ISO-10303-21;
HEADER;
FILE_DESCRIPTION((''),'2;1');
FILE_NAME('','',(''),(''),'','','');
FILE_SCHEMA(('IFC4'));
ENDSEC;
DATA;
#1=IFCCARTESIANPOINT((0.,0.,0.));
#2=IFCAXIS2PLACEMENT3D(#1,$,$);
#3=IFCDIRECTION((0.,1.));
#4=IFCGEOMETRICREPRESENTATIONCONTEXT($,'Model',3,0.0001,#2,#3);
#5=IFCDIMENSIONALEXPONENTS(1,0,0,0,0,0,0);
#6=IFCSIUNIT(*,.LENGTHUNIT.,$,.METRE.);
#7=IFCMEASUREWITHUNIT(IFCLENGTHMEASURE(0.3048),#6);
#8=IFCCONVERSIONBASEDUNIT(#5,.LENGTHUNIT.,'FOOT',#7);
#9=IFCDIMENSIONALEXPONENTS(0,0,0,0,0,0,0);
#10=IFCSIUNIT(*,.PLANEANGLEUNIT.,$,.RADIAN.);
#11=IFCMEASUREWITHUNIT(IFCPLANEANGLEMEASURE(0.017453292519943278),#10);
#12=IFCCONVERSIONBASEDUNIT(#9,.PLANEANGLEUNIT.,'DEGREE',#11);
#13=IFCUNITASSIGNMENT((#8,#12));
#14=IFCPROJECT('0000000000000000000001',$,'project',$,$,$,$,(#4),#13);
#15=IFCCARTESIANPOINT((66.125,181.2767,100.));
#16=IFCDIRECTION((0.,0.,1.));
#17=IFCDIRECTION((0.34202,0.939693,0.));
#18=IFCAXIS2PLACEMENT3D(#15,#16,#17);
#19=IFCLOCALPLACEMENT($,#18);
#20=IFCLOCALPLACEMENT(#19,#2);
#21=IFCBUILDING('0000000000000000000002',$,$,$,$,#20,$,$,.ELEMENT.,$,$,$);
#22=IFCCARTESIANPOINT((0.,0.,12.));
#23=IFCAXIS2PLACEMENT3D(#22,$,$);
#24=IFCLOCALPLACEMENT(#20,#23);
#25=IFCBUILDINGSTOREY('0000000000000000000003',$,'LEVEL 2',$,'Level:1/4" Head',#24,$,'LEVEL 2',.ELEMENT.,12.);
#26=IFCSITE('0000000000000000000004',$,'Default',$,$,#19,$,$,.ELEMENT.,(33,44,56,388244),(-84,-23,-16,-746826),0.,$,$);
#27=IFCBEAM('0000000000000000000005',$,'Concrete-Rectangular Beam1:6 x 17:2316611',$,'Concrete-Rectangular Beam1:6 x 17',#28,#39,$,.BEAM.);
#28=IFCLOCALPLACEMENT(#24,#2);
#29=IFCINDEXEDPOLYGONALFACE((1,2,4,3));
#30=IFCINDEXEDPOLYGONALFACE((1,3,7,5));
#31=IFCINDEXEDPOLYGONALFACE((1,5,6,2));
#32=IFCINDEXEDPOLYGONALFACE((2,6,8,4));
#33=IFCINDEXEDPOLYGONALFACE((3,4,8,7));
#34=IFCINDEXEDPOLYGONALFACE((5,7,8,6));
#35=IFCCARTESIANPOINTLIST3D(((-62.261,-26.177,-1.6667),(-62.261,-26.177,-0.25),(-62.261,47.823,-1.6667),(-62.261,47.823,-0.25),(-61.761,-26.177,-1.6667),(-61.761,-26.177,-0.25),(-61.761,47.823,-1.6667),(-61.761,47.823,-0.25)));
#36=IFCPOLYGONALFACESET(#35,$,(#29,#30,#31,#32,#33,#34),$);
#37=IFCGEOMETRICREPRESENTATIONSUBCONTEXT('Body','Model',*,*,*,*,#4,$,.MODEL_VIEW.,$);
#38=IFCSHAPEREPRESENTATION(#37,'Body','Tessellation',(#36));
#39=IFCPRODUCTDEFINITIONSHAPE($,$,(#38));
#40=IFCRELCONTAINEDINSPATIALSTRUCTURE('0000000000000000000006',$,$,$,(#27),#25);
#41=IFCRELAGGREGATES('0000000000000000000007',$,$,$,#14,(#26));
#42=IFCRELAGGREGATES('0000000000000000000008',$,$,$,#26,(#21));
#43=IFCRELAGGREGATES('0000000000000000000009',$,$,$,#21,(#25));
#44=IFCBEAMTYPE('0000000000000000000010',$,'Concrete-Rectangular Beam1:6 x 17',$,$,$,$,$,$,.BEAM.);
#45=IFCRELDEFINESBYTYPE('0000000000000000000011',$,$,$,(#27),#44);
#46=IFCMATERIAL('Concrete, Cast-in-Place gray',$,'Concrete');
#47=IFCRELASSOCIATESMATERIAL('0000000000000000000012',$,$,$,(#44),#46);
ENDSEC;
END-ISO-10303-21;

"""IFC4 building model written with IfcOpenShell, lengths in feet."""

from ifc_helpers import new_model, entity, si_unit, converted_unit, direction, frame, frame_2d, origin, place, context, subcontext, project, spatial, rectangle, extrude, source, transform, mapped, material, material_profile, profile_set, type_object, type_shapes, element, save


model = new_model("IFC4")

# Units and contexts
model_context = context("Model", 3, precision=0.0001, world=origin(), true_north=direction((0.0, 1.0)))
body_context = subcontext(model_context, "Body", "Model", "MODEL_VIEW")
ifc_project = project(units=[converted_unit("LENGTHUNIT", "FOOT", entity("IfcLengthMeasure", 0.3048), si_unit("LENGTHUNIT", "METRE"), dimensions=[1, 0, 0, 0, 0, 0, 0]), converted_unit("PLANEANGLEUNIT", "DEGREE", entity("IfcPlaneAngleMeasure", 0.017453292519943278), si_unit("PLANEANGLEUNIT", "RADIAN"), dimensions=[0, 0, 0, 0, 0, 0, 0])], contexts=[model_context])

# Site, building, storey
site_placement = place(None, frame((66.125, 181.2767, 100.0), z_axis=(0.0, 0.0, 1.0), x_axis=(0.34202, 0.939693, 0.0)))
site = spatial("IfcSite", under=ifc_project, at=site_placement, Name="Default", CompositionType="ELEMENT", RefLatitude=(33, 44, 56, 388244), RefLongitude=(-84, -23, -16, -746826), RefElevation=0.0)
building_placement = place(site_placement, origin())
building = spatial("IfcBuilding", under=site, at=building_placement, CompositionType="ELEMENT")
storey_placement = place(building_placement, frame((0.0, 0.0, 12.0)))
storey = spatial("IfcBuildingStorey", under=building, at=storey_placement, Name="LEVEL 2", ObjectType="Level:1/4\" Head", LongName="LEVEL 2", CompositionType="ELEMENT", Elevation=12.0)

# Beam
ifc_material = material(Name="Concrete, Cast-in-Place gray", Category="Concrete")
ifc_material_profile_1 = material_profile(ifc_material, rectangle(XDim=1.4167, YDim=0.5, at=frame_2d((0.0, 0.0), x_axis=(0.0, 1.0))), Name="6 x 17")
ifc_profile_set_1 = profile_set([ifc_material_profile_1], Name="6 x 17")
beam_type_1 = type_object("IfcBeamType", Name="Concrete-Rectangular Beam1:6 x 17", PredefinedType="BEAM", material=ifc_profile_set_1)
shared_shape_1 = source(origin(), body_context, "Body", "SweptSolid", [
    extrude(rectangle(XDim=1.4167, YDim=0.5, at=frame_2d((0.0, 0.0), x_axis=(0.0, 1.0))), frame((-62.011, 47.823, 11.0417), z_axis=(0.0, -1.0, 0.0), x_axis=(-1.0, 0.0, 0.0)), (0.0, 0.0, 1.0), 74.0),
])
type_shapes(beam_type_1, [shared_shape_1])
beam_1_placement = place(storey_placement, frame((0.0, 0.0, -12.0)))
element("IfcBeam", 1, at=beam_1_placement, inside=storey, type_object=beam_type_1, Name="Concrete-Rectangular Beam1:6 x 17:2316611", ObjectType="Concrete-Rectangular Beam1:6 x 17", PredefinedType="BEAM", context=body_context, shape_type="MappedRepresentation", body=[
    mapped(shared_shape_1, transform((0.0, 0.0, 0.0), scale=1.0)),
])

save(model, "model.ifc")
